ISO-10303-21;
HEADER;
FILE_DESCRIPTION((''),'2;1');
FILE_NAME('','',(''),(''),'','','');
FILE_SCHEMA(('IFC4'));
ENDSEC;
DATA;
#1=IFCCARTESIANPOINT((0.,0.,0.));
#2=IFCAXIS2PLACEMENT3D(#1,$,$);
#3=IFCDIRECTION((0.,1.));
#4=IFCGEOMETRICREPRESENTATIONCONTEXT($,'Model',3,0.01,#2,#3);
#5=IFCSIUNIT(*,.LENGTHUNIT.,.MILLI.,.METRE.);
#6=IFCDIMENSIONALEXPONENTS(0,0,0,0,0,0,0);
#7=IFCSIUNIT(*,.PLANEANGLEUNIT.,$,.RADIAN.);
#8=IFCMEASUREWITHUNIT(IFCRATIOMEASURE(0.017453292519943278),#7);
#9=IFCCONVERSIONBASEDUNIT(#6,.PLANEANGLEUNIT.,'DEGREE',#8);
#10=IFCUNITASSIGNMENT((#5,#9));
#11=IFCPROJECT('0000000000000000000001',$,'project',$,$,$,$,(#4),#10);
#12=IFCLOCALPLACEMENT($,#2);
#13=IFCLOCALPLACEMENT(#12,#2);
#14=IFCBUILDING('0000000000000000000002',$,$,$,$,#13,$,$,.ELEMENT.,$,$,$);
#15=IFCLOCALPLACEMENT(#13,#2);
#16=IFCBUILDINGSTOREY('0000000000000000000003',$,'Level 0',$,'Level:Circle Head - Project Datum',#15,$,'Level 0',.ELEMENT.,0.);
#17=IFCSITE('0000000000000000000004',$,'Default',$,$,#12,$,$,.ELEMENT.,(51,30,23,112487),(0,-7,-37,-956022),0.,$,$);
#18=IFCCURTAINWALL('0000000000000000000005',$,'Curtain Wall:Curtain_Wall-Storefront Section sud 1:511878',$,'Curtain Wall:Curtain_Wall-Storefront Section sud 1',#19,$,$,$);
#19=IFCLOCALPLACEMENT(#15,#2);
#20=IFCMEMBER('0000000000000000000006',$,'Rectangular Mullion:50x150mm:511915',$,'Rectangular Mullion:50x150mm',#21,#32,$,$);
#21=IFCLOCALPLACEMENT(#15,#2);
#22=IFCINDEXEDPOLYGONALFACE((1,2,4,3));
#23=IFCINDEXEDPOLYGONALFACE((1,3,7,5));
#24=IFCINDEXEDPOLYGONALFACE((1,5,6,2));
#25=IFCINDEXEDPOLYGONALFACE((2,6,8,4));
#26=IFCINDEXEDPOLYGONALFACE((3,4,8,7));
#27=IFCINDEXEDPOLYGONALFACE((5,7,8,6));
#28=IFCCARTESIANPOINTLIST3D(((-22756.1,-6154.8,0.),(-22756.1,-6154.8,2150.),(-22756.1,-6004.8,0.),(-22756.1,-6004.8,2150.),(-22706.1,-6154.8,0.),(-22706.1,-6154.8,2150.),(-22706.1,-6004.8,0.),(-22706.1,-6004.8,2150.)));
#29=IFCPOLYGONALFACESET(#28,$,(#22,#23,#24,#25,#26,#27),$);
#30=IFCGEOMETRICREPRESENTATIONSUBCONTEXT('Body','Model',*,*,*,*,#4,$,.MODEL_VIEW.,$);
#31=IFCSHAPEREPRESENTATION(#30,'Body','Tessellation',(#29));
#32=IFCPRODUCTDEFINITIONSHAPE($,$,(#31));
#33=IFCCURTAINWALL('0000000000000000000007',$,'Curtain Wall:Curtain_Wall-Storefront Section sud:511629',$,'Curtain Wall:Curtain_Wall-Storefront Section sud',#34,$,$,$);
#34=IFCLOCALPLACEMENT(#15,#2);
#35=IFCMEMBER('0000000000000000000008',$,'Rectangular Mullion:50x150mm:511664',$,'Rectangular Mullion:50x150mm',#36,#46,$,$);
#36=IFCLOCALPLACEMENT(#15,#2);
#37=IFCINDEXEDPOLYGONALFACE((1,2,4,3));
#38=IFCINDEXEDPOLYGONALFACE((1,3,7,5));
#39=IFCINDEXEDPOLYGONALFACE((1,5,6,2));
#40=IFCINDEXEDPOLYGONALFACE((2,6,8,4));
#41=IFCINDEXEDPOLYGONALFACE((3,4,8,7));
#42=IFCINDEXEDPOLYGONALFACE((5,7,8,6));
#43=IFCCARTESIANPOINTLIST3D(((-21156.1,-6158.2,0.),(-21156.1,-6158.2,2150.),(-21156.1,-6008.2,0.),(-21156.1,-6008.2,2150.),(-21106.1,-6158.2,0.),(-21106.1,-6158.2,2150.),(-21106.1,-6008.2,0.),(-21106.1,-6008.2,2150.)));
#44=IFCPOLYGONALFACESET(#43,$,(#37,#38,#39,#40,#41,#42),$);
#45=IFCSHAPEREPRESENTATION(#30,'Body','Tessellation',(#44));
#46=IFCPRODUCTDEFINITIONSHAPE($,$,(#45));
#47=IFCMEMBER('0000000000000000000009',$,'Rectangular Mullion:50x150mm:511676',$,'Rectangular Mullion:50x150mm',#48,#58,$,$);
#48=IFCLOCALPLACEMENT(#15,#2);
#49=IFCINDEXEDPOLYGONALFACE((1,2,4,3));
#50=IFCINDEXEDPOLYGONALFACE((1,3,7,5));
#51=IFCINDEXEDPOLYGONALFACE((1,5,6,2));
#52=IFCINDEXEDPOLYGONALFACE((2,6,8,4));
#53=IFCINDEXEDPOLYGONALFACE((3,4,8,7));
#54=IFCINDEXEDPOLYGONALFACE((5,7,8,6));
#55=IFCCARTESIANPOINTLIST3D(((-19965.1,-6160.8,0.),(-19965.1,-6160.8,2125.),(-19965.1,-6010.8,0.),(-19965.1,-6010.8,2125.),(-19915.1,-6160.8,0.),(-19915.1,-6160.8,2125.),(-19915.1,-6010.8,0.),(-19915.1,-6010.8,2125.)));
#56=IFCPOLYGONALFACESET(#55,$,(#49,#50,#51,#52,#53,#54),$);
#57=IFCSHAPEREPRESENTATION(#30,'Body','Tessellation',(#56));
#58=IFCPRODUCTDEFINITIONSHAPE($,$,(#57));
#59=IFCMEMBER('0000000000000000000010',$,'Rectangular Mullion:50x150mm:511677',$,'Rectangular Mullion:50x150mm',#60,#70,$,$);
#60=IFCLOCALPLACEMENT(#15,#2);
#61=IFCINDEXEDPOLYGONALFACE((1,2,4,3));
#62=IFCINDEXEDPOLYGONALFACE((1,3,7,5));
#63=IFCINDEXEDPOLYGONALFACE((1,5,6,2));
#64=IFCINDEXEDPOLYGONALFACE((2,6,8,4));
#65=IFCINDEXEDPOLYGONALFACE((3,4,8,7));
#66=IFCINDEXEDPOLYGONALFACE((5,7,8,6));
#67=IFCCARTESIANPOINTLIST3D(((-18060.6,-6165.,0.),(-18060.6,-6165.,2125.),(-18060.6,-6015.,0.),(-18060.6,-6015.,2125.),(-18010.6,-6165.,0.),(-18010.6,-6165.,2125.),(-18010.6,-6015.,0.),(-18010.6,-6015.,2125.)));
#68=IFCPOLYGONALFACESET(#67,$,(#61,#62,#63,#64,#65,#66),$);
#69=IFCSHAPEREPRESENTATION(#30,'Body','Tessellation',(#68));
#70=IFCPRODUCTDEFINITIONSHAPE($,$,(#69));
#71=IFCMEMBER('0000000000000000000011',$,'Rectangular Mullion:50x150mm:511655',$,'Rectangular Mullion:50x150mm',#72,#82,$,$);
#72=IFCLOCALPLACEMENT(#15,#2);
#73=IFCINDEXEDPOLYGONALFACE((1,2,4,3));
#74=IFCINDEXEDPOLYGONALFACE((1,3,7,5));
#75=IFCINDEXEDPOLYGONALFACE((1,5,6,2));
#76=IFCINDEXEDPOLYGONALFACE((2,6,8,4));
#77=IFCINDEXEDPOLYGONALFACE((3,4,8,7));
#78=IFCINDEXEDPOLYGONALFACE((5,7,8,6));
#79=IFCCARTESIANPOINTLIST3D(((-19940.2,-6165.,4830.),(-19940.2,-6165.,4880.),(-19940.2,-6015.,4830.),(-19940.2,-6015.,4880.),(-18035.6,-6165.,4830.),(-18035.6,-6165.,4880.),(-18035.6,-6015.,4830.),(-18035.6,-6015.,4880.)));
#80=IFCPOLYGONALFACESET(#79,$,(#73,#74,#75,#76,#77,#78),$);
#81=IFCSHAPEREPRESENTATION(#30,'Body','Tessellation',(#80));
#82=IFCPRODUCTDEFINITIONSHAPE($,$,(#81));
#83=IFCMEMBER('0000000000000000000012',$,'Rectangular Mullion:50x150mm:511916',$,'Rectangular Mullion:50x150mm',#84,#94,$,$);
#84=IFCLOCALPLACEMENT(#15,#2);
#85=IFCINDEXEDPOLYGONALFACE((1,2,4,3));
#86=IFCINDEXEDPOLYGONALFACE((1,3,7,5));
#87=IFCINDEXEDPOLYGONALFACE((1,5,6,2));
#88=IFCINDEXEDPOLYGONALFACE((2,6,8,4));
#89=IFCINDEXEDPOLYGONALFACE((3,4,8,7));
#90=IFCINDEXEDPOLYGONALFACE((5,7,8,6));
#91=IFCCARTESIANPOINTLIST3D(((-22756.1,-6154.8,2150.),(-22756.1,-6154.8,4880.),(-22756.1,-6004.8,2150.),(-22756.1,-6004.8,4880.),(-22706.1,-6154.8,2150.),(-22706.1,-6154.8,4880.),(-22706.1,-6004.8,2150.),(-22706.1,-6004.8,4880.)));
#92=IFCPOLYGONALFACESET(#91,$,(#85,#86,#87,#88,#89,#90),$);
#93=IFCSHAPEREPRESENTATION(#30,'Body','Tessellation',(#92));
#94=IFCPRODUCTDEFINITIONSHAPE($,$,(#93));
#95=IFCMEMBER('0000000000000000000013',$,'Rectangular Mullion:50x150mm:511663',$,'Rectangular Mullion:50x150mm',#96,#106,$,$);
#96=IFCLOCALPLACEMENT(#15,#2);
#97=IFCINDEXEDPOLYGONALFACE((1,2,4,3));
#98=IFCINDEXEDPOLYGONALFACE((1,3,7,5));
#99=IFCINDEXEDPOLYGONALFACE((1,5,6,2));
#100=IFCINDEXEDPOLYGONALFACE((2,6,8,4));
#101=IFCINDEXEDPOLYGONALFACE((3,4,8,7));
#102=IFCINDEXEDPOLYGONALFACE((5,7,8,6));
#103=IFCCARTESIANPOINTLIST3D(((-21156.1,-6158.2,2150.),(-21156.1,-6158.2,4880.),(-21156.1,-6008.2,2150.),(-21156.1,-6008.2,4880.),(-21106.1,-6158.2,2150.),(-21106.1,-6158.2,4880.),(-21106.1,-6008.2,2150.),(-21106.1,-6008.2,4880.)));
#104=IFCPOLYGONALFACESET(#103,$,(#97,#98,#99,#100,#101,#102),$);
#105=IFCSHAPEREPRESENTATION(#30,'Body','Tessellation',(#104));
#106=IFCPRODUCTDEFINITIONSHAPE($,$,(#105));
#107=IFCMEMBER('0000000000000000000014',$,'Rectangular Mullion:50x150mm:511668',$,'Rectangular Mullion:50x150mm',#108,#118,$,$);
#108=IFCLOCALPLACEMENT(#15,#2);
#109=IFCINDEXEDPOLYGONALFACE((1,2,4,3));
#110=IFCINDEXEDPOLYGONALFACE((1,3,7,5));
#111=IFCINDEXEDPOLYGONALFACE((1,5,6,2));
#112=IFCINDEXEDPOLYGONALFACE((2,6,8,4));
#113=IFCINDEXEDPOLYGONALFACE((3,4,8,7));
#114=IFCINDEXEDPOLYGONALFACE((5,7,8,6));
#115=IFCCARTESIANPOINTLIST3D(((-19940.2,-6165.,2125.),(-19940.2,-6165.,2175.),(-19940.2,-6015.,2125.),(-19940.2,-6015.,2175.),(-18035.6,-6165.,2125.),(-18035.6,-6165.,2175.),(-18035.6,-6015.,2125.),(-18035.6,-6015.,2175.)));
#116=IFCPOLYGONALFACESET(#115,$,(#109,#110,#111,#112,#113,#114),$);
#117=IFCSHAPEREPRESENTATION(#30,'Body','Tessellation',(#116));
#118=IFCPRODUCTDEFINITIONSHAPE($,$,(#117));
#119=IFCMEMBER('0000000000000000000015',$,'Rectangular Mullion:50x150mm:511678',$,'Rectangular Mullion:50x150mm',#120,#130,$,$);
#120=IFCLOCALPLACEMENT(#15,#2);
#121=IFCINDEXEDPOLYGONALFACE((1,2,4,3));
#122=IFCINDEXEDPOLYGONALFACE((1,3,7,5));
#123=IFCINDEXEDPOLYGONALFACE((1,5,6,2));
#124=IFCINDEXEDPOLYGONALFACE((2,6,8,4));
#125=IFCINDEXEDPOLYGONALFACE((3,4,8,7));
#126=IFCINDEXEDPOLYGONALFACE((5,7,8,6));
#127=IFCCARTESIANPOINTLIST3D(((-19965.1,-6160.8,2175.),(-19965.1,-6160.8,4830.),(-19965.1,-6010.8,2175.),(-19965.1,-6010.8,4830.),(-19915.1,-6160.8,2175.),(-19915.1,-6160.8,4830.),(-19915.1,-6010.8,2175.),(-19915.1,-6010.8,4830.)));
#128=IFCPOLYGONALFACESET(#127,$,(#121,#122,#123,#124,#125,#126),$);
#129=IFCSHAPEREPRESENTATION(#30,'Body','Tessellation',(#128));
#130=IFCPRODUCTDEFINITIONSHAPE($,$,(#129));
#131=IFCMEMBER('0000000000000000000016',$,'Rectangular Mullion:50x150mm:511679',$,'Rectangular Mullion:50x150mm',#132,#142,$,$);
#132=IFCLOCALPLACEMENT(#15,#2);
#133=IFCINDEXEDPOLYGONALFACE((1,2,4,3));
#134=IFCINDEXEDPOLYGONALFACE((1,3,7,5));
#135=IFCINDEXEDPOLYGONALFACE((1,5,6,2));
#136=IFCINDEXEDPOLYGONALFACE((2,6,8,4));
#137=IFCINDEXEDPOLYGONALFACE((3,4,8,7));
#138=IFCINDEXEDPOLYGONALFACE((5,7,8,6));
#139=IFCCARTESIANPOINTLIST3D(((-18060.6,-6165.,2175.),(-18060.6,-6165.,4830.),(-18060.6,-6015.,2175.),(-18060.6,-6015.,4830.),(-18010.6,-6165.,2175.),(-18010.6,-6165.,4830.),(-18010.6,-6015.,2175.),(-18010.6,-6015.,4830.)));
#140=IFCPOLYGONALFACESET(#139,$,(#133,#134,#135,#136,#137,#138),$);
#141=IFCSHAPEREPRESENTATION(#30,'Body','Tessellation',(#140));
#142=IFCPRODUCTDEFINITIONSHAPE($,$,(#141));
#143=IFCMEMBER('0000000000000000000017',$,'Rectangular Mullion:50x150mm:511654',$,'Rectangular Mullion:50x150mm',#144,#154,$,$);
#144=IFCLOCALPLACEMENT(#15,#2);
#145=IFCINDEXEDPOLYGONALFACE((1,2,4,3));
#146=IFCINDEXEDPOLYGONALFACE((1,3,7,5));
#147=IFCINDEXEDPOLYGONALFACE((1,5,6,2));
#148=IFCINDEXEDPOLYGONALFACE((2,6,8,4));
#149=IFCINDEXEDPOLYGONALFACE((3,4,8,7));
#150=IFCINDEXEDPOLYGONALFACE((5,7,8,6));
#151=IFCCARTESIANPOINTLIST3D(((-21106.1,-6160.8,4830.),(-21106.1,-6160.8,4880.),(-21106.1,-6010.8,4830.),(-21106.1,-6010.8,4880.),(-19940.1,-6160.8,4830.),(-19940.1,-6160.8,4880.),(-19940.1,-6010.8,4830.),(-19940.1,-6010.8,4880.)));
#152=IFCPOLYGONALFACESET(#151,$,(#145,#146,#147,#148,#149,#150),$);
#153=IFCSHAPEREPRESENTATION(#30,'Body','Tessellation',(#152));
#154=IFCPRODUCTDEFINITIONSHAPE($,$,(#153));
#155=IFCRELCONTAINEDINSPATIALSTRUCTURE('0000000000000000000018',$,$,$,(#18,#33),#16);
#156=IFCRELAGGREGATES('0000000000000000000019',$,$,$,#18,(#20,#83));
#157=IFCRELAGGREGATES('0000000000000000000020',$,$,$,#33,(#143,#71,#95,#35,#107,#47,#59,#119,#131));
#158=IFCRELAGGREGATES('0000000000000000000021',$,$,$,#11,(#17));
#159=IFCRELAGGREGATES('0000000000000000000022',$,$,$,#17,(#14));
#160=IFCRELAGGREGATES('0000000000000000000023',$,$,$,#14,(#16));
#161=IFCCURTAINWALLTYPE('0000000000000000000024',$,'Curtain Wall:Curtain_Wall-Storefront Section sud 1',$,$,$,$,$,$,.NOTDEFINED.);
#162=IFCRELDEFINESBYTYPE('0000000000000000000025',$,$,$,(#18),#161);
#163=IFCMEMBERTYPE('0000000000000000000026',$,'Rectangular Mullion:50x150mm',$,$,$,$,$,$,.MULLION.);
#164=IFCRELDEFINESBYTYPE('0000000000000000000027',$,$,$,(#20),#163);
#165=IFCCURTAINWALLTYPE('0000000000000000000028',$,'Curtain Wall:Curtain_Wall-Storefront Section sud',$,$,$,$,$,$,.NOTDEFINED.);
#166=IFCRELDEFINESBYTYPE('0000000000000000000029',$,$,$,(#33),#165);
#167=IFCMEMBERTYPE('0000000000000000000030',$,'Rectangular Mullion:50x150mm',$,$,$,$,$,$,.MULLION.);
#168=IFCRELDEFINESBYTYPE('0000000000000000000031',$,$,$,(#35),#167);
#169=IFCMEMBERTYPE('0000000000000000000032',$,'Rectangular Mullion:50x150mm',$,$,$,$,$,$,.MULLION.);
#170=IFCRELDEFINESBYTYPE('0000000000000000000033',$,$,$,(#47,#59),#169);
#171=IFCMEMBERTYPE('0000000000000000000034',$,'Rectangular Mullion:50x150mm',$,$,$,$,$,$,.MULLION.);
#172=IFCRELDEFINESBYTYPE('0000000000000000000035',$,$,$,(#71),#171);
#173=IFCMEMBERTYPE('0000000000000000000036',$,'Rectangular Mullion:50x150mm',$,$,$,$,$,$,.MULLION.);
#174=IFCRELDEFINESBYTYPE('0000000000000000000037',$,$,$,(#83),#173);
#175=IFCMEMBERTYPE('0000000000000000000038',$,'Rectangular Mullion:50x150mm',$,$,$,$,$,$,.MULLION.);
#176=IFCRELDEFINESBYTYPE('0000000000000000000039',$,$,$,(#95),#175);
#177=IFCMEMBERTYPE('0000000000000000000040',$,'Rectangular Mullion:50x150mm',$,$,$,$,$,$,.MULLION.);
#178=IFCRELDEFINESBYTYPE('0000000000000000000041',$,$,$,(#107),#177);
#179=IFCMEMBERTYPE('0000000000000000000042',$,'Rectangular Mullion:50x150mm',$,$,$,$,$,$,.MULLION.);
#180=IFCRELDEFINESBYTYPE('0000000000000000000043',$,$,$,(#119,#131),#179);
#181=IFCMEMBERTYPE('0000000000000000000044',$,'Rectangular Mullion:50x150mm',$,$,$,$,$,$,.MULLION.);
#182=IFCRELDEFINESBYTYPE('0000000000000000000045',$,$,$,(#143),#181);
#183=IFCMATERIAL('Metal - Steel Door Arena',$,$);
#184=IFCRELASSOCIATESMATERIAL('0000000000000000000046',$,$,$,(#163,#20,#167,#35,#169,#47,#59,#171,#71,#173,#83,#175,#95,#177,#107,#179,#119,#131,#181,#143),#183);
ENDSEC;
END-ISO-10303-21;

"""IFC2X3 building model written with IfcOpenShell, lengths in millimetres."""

from ifc_helpers import new_model, entity, si_unit, converted_unit, direction, frame, origin, origin_2d_with_axis, place, context, subcontext, project, spatial, rectangle, extrude, source, transform, mapped, material, type_object, type_shapes, element, aggregate, save


model = new_model("IFC2X3")

# Units and contexts
model_context = context("Model", 3, precision=0.01, world=origin(), true_north=direction((0.0, 1.0)))
body_context = subcontext(model_context, "Body", "Model", "MODEL_VIEW")
ifc_project = project(units=[si_unit("LENGTHUNIT", "METRE", prefix="MILLI"), converted_unit("PLANEANGLEUNIT", "DEGREE", entity("IfcRatioMeasure", 0.017453292519943278), si_unit("PLANEANGLEUNIT", "RADIAN"), dimensions=[0, 0, 0, 0, 0, 0, 0])], contexts=[model_context])

# Site, building, storey
site_placement = place(None, origin())
site = spatial("IfcSite", under=ifc_project, at=site_placement, Name="Default", CompositionType="ELEMENT", RefLatitude=(51, 30, 23, 112487), RefLongitude=(0, -7, -37, -956022), RefElevation=0.0)
building_placement = place(site_placement, origin())
building = spatial("IfcBuilding", under=site, at=building_placement, CompositionType="ELEMENT")
storey_placement = place(building_placement, origin())
storey = spatial("IfcBuildingStorey", under=building, at=storey_placement, Name="Level 0", ObjectType="Level:Circle Head - Project Datum", LongName="Level 0", CompositionType="ELEMENT", Elevation=0.0)

# Curtain wall, member
curtain_wall_type_1 = type_object("IfcCurtainWallType", Name="Curtain Wall:Curtain_Wall-Storefront Section sud 1", PredefinedType="NOTDEFINED")
curtain_wall_1_placement = place(storey_placement, origin())
curtain_wall_1 = element("IfcCurtainWall", 1, at=curtain_wall_1_placement, inside=storey, type_object=curtain_wall_type_1, Name="Curtain Wall:Curtain_Wall-Storefront Section sud 1:511878", ObjectType="Curtain Wall:Curtain_Wall-Storefront Section sud 1")
ifc_material_1 = material(Name="Metal - Steel Door Arena")
member_type_1 = type_object("IfcMemberType", Name="Rectangular Mullion:50x150mm", PredefinedType="MULLION", material=ifc_material_1)
shared_shape_1 = source(origin(), body_context, "Body", "SweptSolid", [
    extrude(rectangle(XDim=150.0, YDim=50.0, at=origin_2d_with_axis()), frame((-25.0, 0.0, -2150.0), z_axis=(0.0, 0.0, 1.0), x_axis=(0.0, -1.0, 0.0)), (0.0, 0.0, 1.0), 2150.0),
])
type_shapes(member_type_1, [shared_shape_1])
member_1_placement = place(curtain_wall_1_placement, frame((-22706.1, -6079.8, 0.0), z_axis=(0.0, 0.0, -1.0), x_axis=(1.0, 0.0, 0.0)))
member_1 = element("IfcMember", 2, at=member_1_placement, type_object=member_type_1, material=ifc_material_1, Name="Rectangular Mullion:50x150mm:511915", ObjectType="Rectangular Mullion:50x150mm", context=body_context, shape_type="MappedRepresentation", body=[
    mapped(shared_shape_1, transform((0.0, 0.0, 0.0), scale=1.0)),
])

# Curtain wall, members
curtain_wall_type_2 = type_object("IfcCurtainWallType", Name="Curtain Wall:Curtain_Wall-Storefront Section sud", PredefinedType="NOTDEFINED")
curtain_wall_2_placement = place(storey_placement, origin())
curtain_wall_2 = element("IfcCurtainWall", 3, at=curtain_wall_2_placement, inside=storey, type_object=curtain_wall_type_2, Name="Curtain Wall:Curtain_Wall-Storefront Section sud:511629", ObjectType="Curtain Wall:Curtain_Wall-Storefront Section sud")
member_type_2 = type_object("IfcMemberType", Name="Rectangular Mullion:50x150mm", PredefinedType="MULLION", material=ifc_material_1)
shared_shape_2 = source(origin(), body_context, "Body", "SweptSolid", [
    extrude(rectangle(XDim=150.0, YDim=50.0, at=origin_2d_with_axis()), frame((-25.0, 0.0, -2150.0), z_axis=(0.0, 0.0, 1.0), x_axis=(0.0, -1.0, 0.0)), (0.0, 0.0, 1.0), 2150.0),
])
type_shapes(member_type_2, [shared_shape_2])
member_2_placement = place(curtain_wall_2_placement, frame((-21156.1, -6083.2, 2150.0), z_axis=(0.0, 0.0, 1.0), x_axis=(-1.0, 0.0, 0.0)))
member_2 = element("IfcMember", 4, at=member_2_placement, type_object=member_type_2, material=ifc_material_1, Name="Rectangular Mullion:50x150mm:511664", ObjectType="Rectangular Mullion:50x150mm", context=body_context, shape_type="MappedRepresentation", body=[
    mapped(shared_shape_2, transform((0.0, 0.0, 0.0), scale=1.0)),
])
member_type_3 = type_object("IfcMemberType", Name="Rectangular Mullion:50x150mm", PredefinedType="MULLION", material=ifc_material_1)
shared_shape_3 = source(origin(), body_context, "Body", "SweptSolid", [
    extrude(rectangle(XDim=150.0, YDim=50.0, at=origin_2d_with_axis()), frame((0.0, 0.0, -2125.0), z_axis=(0.0, 0.0, 1.0), x_axis=(0.0, -1.0, 0.0)), (0.0, 0.0, 1.0), 2125.0),
])
type_shapes(member_type_3, [shared_shape_3])
member_3_placement = place(curtain_wall_2_placement, frame((-19940.1, -6085.8, 0.0), z_axis=(0.0, 0.0, -1.0), x_axis=(1.0, 0.0, 0.0)))
member_3 = element("IfcMember", 5, at=member_3_placement, type_object=member_type_3, material=ifc_material_1, Name="Rectangular Mullion:50x150mm:511676", ObjectType="Rectangular Mullion:50x150mm", context=body_context, shape_type="MappedRepresentation", body=[
    mapped(shared_shape_3, transform((0.0, 0.0, 0.0), scale=1.0)),
])
member_4_placement = place(curtain_wall_2_placement, frame((-18035.6, -6090.0, 0.0), z_axis=(0.0, 0.0, -1.0), x_axis=(1.0, 0.0, 0.0)))
member_4 = element("IfcMember", 6, at=member_4_placement, type_object=member_type_3, material=ifc_material_1, Name="Rectangular Mullion:50x150mm:511677", ObjectType="Rectangular Mullion:50x150mm", context=body_context, shape_type="MappedRepresentation", body=[
    mapped(shared_shape_3, transform((0.0, 0.0, 0.0), scale=1.0)),
])
member_type_4 = type_object("IfcMemberType", Name="Rectangular Mullion:50x150mm", PredefinedType="MULLION", material=ifc_material_1)
shared_shape_4 = source(origin(), body_context, "Body", "SweptSolid", [
    extrude(rectangle(XDim=150.0, YDim=50.0, at=origin_2d_with_axis()), frame((-25.0, 0.0, -1904.5), z_axis=(0.0, 0.0, 1.0), x_axis=(0.0, -1.0, 0.0)), (0.0, 0.0, 1.0), 1904.5),
])
type_shapes(member_type_4, [shared_shape_4])
member_5_placement = place(curtain_wall_2_placement, frame((-18035.6, -6090.0, 4880.0), z_axis=(1.0, 0.0, 0.0), x_axis=(0.0, 0.0, 1.0)))
member_5 = element("IfcMember", 7, at=member_5_placement, type_object=member_type_4, material=ifc_material_1, Name="Rectangular Mullion:50x150mm:511655", ObjectType="Rectangular Mullion:50x150mm", context=body_context, shape_type="MappedRepresentation", body=[
    mapped(shared_shape_4, transform((0.0, 0.0, 0.0), scale=1.0)),
])

# Members
member_type_5 = type_object("IfcMemberType", Name="Rectangular Mullion:50x150mm", PredefinedType="MULLION", material=ifc_material_1)
shared_shape_5 = source(origin(), body_context, "Body", "SweptSolid", [
    extrude(rectangle(XDim=150.0, YDim=50.0, at=origin_2d_with_axis()), frame((-25.0, 0.0, -2730.0), z_axis=(0.0, 0.0, 1.0), x_axis=(0.0, -1.0, 0.0)), (0.0, 0.0, 1.0), 2730.0),
])
type_shapes(member_type_5, [shared_shape_5])
member_6_placement = place(curtain_wall_1_placement, frame((-22706.1, -6079.8, 2150.0), z_axis=(0.0, 0.0, -1.0), x_axis=(1.0, 0.0, 0.0)))
member_6 = element("IfcMember", 8, at=member_6_placement, type_object=member_type_5, material=ifc_material_1, Name="Rectangular Mullion:50x150mm:511916", ObjectType="Rectangular Mullion:50x150mm", context=body_context, shape_type="MappedRepresentation", body=[
    mapped(shared_shape_5, transform((0.0, 0.0, 0.0), scale=1.0)),
])
member_type_6 = type_object("IfcMemberType", Name="Rectangular Mullion:50x150mm", PredefinedType="MULLION", material=ifc_material_1)
shared_shape_6 = source(origin(), body_context, "Body", "SweptSolid", [
    extrude(rectangle(XDim=150.0, YDim=50.0, at=origin_2d_with_axis()), frame((-25.0, 0.0, -2730.0), z_axis=(0.0, 0.0, 1.0), x_axis=(0.0, -1.0, 0.0)), (0.0, 0.0, 1.0), 2730.0),
])
type_shapes(member_type_6, [shared_shape_6])
member_7_placement = place(curtain_wall_2_placement, frame((-21156.1, -6083.2, 4880.0), z_axis=(0.0, 0.0, 1.0), x_axis=(-1.0, 0.0, 0.0)))
member_7 = element("IfcMember", 9, at=member_7_placement, type_object=member_type_6, material=ifc_material_1, Name="Rectangular Mullion:50x150mm:511663", ObjectType="Rectangular Mullion:50x150mm", context=body_context, shape_type="MappedRepresentation", body=[
    mapped(shared_shape_6, transform((0.0, 0.0, 0.0), scale=1.0)),
])
member_type_7 = type_object("IfcMemberType", Name="Rectangular Mullion:50x150mm", PredefinedType="MULLION", material=ifc_material_1)
shared_shape_7 = source(origin(), body_context, "Body", "SweptSolid", [
    extrude(rectangle(XDim=150.0, YDim=50.0, at=origin_2d_with_axis()), frame((0.0, 0.0, -1904.5), z_axis=(0.0, 0.0, 1.0), x_axis=(0.0, -1.0, 0.0)), (0.0, 0.0, 1.0), 1904.5),
])
type_shapes(member_type_7, [shared_shape_7])
member_8_placement = place(curtain_wall_2_placement, frame((-18035.6, -6090.0, 2150.0), z_axis=(1.0, 0.0, 0.0), x_axis=(0.0, 0.0, 1.0)))
member_8 = element("IfcMember", 10, at=member_8_placement, type_object=member_type_7, material=ifc_material_1, Name="Rectangular Mullion:50x150mm:511668", ObjectType="Rectangular Mullion:50x150mm", context=body_context, shape_type="MappedRepresentation", body=[
    mapped(shared_shape_7, transform((0.0, 0.0, 0.0), scale=1.0)),
])
member_type_8 = type_object("IfcMemberType", Name="Rectangular Mullion:50x150mm", PredefinedType="MULLION", material=ifc_material_1)
shared_shape_8 = source(origin(), body_context, "Body", "SweptSolid", [
    extrude(rectangle(XDim=150.0, YDim=50.0, at=origin_2d_with_axis()), frame((0.0, 0.0, -2655.0), z_axis=(0.0, 0.0, 1.0), x_axis=(0.0, -1.0, 0.0)), (0.0, 0.0, 1.0), 2655.0),
])
type_shapes(member_type_8, [shared_shape_8])
member_9_placement = place(curtain_wall_2_placement, frame((-19940.1, -6085.8, 2175.0), z_axis=(0.0, 0.0, -1.0), x_axis=(1.0, 0.0, 0.0)))
member_9 = element("IfcMember", 11, at=member_9_placement, type_object=member_type_8, material=ifc_material_1, Name="Rectangular Mullion:50x150mm:511678", ObjectType="Rectangular Mullion:50x150mm", context=body_context, shape_type="MappedRepresentation", body=[
    mapped(shared_shape_8, transform((0.0, 0.0, 0.0), scale=1.0)),
])
member_10_placement = place(curtain_wall_2_placement, frame((-18035.6, -6090.0, 2175.0), z_axis=(0.0, 0.0, -1.0), x_axis=(1.0, 0.0, 0.0)))
member_10 = element("IfcMember", 12, at=member_10_placement, type_object=member_type_8, material=ifc_material_1, Name="Rectangular Mullion:50x150mm:511679", ObjectType="Rectangular Mullion:50x150mm", context=body_context, shape_type="MappedRepresentation", body=[
    mapped(shared_shape_8, transform((0.0, 0.0, 0.0), scale=1.0)),
])
member_type_9 = type_object("IfcMemberType", Name="Rectangular Mullion:50x150mm", PredefinedType="MULLION", material=ifc_material_1)
shared_shape_9 = source(origin(), body_context, "Body", "SweptSolid", [
    extrude(rectangle(XDim=150.0, YDim=50.0, at=origin_2d_with_axis()), frame((-25.0, 0.0, -1166.0), z_axis=(0.0, 0.0, 1.0), x_axis=(0.0, -1.0, 0.0)), (0.0, 0.0, 1.0), 1166.0),
])
type_shapes(member_type_9, [shared_shape_9])
member_11_placement = place(curtain_wall_2_placement, frame((-19940.1, -6085.8, 4880.0), z_axis=(1.0, 0.0, 0.0), x_axis=(0.0, 0.0, 1.0)))
member_11 = element("IfcMember", 13, at=member_11_placement, type_object=member_type_9, material=ifc_material_1, Name="Rectangular Mullion:50x150mm:511654", ObjectType="Rectangular Mullion:50x150mm", context=body_context, shape_type="MappedRepresentation", body=[
    mapped(shared_shape_9, transform((0.0, 0.0, 0.0), scale=1.0)),
])
aggregate(curtain_wall_1, [member_1, member_6])

aggregate(curtain_wall_2, [member_11, member_5, member_7, member_2, member_8, member_3, member_4, member_9, member_10])

save(model, "model.ifc")
